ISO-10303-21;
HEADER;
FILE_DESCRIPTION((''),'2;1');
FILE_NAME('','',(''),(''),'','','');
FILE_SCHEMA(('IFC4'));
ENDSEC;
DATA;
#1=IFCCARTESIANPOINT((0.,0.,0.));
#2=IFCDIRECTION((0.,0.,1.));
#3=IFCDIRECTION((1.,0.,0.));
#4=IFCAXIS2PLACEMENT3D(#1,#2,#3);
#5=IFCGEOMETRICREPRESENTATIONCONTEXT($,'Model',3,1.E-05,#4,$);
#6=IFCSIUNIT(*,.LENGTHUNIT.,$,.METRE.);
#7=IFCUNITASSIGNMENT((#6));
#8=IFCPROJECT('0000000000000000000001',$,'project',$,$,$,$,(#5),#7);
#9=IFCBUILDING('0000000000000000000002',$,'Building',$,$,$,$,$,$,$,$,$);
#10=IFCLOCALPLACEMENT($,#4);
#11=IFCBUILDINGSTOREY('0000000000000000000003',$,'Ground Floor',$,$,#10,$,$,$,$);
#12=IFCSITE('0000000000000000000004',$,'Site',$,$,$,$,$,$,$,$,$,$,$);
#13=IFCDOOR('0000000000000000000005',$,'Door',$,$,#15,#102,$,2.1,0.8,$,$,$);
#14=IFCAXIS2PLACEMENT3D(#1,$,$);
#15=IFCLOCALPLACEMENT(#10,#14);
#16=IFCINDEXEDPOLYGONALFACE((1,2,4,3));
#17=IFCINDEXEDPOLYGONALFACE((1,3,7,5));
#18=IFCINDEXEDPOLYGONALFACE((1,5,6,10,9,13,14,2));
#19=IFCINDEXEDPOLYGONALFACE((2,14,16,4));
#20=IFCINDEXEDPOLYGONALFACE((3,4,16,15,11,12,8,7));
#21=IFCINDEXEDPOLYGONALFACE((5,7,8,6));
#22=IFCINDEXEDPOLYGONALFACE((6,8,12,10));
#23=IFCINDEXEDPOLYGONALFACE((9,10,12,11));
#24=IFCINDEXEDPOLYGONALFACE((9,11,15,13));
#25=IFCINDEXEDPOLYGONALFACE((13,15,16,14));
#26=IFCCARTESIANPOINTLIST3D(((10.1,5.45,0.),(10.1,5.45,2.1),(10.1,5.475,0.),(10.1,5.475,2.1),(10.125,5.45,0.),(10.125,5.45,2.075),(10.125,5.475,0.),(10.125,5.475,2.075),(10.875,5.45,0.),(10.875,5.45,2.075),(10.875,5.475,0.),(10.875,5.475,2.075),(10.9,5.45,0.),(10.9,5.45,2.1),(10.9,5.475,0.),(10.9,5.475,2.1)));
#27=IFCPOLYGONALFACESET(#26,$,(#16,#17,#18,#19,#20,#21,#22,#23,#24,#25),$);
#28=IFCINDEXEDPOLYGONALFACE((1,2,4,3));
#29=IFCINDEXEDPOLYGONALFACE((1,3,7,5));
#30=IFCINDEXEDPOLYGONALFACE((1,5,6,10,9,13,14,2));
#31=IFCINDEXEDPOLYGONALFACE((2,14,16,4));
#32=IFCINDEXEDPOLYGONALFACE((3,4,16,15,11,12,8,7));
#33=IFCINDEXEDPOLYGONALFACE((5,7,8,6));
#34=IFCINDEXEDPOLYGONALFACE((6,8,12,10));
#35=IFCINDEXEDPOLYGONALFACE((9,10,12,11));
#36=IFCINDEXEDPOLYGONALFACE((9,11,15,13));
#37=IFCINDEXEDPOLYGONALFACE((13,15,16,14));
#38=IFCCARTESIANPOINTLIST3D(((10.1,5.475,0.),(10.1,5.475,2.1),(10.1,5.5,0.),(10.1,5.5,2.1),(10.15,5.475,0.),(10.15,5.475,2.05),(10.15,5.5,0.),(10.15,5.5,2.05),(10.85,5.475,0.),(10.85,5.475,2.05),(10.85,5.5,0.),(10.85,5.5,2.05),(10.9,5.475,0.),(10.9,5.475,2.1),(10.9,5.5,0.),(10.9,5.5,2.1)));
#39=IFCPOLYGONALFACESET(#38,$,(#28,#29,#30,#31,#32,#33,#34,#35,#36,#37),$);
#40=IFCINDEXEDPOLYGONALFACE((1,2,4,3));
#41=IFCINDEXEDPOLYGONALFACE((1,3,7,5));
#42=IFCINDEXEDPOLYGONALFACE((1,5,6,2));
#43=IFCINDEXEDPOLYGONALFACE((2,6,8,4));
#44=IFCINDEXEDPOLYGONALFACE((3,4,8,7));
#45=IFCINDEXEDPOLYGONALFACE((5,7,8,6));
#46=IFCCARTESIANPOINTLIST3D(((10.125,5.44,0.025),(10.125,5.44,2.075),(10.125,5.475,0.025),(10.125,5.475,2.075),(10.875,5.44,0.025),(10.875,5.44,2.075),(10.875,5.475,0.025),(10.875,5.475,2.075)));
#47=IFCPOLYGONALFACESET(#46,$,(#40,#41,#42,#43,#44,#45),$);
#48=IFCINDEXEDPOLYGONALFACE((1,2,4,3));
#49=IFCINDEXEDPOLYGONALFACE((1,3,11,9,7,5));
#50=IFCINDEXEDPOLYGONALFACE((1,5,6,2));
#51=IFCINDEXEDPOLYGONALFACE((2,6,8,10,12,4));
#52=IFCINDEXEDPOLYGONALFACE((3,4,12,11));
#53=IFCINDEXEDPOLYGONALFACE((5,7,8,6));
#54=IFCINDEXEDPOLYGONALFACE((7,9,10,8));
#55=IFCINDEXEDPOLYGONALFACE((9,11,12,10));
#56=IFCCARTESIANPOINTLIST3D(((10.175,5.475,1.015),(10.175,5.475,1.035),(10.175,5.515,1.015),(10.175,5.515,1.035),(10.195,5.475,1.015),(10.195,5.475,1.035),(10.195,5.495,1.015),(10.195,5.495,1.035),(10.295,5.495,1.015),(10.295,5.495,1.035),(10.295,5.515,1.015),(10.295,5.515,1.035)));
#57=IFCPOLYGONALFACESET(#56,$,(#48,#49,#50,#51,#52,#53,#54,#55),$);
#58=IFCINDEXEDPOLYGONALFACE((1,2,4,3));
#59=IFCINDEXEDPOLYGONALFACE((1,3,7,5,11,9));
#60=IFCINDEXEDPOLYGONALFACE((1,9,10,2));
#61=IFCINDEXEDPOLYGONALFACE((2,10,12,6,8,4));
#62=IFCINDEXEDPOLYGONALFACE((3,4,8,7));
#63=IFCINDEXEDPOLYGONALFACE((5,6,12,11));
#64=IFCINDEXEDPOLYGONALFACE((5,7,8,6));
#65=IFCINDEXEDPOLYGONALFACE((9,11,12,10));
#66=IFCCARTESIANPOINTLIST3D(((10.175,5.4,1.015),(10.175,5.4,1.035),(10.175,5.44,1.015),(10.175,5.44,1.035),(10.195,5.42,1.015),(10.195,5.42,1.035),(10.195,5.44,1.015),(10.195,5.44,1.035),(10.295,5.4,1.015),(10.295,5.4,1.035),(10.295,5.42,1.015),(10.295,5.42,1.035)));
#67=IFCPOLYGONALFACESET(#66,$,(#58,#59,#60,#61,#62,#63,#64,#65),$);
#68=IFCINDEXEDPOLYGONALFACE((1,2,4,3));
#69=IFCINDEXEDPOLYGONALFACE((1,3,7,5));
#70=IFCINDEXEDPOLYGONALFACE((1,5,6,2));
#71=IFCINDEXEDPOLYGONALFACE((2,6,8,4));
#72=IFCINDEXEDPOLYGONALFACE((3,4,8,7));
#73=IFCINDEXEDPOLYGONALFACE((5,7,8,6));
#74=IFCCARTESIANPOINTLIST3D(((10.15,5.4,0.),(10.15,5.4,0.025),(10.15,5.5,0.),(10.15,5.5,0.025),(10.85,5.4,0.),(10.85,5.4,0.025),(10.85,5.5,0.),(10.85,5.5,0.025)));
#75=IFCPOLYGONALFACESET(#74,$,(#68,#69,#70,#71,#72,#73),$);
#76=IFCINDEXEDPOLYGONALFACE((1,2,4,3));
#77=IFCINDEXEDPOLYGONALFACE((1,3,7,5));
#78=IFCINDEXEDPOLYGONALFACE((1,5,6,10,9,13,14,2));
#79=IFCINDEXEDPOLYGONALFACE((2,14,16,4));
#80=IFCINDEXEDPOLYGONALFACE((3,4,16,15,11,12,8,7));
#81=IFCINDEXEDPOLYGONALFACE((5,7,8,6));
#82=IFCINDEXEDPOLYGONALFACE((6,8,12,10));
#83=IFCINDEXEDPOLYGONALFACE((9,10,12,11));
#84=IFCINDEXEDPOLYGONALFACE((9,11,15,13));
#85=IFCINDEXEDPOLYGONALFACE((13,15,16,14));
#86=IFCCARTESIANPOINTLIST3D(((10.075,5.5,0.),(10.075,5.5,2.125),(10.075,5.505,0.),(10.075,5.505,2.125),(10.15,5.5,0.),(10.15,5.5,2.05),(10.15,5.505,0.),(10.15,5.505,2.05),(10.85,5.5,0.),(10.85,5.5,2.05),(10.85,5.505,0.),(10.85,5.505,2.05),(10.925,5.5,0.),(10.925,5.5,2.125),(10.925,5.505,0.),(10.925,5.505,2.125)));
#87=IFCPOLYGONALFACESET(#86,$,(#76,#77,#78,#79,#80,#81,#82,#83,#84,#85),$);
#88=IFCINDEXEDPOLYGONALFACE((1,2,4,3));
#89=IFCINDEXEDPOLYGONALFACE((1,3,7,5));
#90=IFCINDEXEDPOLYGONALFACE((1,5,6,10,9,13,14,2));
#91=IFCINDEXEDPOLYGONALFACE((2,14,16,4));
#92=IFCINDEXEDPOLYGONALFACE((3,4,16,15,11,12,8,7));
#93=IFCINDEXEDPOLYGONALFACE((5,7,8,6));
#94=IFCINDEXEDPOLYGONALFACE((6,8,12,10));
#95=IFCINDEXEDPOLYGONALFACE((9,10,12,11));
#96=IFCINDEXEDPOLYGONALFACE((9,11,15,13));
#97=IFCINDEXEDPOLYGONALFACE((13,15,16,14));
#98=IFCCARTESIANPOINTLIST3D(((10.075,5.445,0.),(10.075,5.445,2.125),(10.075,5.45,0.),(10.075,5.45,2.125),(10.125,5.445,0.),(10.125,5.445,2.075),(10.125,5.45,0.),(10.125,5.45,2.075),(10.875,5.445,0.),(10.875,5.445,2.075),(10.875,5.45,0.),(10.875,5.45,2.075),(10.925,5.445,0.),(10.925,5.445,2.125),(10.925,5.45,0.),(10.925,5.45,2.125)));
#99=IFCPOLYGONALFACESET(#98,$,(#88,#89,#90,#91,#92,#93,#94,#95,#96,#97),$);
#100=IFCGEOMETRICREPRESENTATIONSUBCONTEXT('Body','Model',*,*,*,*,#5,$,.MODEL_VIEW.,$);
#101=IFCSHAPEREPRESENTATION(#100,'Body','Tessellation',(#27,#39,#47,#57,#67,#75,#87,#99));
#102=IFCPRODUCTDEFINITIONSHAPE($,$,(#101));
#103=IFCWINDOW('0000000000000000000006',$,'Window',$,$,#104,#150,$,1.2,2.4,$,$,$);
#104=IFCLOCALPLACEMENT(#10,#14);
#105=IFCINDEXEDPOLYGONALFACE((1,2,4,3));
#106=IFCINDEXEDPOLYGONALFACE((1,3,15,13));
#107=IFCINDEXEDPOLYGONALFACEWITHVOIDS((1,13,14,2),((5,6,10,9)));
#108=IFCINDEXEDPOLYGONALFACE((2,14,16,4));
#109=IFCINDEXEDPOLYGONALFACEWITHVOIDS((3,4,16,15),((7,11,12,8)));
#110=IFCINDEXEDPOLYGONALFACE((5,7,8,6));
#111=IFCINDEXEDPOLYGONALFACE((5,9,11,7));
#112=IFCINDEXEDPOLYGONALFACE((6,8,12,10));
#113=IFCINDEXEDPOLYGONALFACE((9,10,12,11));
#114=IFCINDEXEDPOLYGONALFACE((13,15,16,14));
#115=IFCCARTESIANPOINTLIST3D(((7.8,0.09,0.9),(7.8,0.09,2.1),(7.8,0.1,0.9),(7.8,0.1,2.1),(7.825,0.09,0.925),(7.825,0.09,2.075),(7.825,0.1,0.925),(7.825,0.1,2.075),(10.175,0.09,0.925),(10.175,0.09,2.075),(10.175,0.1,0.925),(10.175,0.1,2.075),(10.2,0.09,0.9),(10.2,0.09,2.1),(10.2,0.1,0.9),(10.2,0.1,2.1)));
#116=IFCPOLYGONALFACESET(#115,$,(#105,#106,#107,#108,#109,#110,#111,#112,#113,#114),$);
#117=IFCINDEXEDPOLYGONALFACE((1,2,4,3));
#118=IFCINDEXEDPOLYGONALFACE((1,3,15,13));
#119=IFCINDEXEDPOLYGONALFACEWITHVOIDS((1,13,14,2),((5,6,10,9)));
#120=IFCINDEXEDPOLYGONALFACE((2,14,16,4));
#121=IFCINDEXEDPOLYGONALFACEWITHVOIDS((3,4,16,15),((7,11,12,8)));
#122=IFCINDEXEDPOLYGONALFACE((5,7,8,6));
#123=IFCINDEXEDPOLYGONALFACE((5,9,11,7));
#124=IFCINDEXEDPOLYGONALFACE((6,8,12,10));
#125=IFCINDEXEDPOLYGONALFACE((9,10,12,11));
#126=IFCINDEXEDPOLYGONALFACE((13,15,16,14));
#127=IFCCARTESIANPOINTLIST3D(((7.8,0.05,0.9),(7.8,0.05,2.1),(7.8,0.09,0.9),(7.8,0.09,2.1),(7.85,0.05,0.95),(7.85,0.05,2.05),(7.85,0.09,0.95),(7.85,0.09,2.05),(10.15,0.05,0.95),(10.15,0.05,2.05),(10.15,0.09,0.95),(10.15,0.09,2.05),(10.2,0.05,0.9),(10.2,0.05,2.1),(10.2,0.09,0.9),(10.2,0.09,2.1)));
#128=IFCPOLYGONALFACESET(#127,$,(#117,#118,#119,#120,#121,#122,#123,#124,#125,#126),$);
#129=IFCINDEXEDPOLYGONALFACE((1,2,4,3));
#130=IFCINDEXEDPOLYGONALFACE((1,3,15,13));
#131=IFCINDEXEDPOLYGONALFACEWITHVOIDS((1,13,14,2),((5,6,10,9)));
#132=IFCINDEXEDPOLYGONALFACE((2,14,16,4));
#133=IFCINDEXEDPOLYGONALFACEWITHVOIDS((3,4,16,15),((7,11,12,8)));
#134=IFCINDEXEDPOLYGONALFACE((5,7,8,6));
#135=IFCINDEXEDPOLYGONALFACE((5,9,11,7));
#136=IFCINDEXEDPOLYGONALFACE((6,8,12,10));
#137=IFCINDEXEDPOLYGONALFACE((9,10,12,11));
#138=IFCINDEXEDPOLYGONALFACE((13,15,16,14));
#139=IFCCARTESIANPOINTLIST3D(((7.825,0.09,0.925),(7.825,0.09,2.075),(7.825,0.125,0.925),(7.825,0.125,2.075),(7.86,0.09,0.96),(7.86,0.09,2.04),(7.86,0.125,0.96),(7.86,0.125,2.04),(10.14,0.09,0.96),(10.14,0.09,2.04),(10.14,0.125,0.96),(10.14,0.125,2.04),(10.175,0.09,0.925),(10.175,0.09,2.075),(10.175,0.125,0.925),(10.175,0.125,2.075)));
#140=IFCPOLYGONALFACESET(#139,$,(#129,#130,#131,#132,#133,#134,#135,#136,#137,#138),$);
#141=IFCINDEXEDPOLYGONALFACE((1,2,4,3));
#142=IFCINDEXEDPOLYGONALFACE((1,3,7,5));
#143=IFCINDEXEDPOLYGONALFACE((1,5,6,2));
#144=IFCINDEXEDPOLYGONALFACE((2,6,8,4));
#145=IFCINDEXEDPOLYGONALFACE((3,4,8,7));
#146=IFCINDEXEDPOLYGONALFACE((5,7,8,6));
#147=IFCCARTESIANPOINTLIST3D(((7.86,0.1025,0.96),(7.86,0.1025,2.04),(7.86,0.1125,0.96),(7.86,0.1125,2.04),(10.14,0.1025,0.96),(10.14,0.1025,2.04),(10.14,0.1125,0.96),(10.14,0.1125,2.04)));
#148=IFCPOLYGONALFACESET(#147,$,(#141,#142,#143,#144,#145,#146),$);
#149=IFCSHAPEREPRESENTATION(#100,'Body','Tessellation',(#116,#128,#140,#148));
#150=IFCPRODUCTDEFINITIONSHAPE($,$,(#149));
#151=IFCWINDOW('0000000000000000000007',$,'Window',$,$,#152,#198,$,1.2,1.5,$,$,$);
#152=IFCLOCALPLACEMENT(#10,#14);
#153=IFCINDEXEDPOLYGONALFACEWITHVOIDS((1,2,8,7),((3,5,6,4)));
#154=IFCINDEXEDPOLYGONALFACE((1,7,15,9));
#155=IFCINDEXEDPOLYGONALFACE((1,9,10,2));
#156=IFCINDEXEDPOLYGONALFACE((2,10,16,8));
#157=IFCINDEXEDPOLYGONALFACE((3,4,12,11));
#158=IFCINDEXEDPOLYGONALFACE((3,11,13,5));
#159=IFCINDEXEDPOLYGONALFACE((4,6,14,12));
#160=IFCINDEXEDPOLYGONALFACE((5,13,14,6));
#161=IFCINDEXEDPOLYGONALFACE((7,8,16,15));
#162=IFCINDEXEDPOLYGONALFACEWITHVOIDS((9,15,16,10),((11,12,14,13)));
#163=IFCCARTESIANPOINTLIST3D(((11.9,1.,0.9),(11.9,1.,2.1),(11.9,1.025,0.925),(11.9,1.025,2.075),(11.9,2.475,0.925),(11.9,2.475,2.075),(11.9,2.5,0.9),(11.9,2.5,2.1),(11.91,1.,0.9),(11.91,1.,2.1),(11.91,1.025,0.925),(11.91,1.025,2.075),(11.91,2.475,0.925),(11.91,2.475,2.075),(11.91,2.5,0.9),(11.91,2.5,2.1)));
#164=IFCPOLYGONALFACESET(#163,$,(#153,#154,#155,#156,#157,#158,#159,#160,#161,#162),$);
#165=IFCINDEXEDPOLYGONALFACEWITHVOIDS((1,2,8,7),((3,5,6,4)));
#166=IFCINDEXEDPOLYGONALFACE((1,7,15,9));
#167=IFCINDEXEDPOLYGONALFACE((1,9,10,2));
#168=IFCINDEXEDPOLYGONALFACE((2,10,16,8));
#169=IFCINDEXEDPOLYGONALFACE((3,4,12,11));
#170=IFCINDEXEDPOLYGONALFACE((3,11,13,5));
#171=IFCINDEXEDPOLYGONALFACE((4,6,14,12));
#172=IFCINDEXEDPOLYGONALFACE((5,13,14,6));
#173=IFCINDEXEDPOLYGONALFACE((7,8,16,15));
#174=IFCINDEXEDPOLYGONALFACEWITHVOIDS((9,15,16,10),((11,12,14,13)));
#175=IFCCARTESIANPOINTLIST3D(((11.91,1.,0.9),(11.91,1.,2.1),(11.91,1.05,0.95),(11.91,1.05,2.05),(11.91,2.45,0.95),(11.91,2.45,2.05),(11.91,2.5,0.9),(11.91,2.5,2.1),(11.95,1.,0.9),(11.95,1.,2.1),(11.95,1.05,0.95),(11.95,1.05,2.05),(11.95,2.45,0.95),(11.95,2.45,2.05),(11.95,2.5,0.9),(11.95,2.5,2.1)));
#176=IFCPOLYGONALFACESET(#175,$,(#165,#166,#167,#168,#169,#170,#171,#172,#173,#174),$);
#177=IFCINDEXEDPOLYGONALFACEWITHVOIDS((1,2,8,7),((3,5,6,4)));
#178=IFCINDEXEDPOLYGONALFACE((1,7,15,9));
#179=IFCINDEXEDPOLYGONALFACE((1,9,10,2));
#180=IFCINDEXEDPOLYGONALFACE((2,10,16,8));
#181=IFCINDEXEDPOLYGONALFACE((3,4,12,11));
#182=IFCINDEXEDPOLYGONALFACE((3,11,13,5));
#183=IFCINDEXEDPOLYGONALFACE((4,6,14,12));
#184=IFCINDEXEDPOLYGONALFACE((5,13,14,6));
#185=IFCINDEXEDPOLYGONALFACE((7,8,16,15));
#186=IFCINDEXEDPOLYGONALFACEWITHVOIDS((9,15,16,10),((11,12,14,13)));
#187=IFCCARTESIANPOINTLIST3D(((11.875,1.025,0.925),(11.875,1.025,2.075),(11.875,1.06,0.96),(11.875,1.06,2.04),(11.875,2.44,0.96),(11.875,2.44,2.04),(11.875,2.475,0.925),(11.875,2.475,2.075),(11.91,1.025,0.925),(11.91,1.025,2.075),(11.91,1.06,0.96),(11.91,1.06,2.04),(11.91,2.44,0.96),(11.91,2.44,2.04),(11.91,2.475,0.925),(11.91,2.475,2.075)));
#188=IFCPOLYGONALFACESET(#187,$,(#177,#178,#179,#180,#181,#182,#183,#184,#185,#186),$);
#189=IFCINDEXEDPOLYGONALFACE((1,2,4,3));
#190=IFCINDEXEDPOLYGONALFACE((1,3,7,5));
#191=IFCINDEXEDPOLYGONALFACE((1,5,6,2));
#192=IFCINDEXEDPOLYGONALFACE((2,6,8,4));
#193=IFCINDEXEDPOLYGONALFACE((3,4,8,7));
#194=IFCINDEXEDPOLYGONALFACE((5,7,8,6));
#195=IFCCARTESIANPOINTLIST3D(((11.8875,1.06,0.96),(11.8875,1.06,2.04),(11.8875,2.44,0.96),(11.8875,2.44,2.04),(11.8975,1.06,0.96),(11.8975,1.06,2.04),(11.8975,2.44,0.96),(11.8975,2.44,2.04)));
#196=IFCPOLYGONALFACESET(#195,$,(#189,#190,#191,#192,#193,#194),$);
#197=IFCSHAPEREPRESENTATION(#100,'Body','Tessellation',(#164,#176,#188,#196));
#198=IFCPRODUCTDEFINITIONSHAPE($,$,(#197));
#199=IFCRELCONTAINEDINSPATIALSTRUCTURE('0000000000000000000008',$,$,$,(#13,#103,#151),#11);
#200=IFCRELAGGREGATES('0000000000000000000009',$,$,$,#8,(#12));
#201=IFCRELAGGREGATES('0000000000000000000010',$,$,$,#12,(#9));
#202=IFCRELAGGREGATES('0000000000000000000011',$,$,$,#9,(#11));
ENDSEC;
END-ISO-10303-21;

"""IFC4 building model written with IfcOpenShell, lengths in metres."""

from ifc_helpers import new_model, si_unit, frame, origin_with_axes, place, context, subcontext, project, spatial, line, indexed_curve, outline, extrude, element, save


model = new_model("IFC4")

# Units and contexts
model_context = context("Model", 3, precision=1e-05, world=origin_with_axes())
body_context = subcontext(model_context, "Body", "Model", "MODEL_VIEW")
ifc_project = project(units=[si_unit("LENGTHUNIT", "METRE")], contexts=[model_context])

# Site, building, storey
site = spatial("IfcSite", under=ifc_project, Name="Site")
building = spatial("IfcBuilding", under=site, Name="Building")
storey_placement = place(None, origin_with_axes())
storey = spatial("IfcBuildingStorey", under=building, at=storey_placement, Name="Ground Floor")

# Door
door_1_placement = place(storey_placement, frame((10.9, 5.5, 0.0), z_axis=(0.0, 0.0, 1.0), x_axis=(-1.0, 0.0, 0.0)))
element("IfcDoor", 1, at=door_1_placement, inside=storey, Name="Door", OverallHeight=2.1, OverallWidth=0.8, context=body_context, shape_type="SweptSolid", body=[
    extrude(outline(indexed_curve([(0.0, 0.0), (0.0, 2.1), (0.8, 2.1), (0.8, 0.0), (0.775, 0.0), (0.775, 2.075), (0.025, 2.075), (0.025, 0.0)], segments=[line(1, 2, 3, 4, 5, 6, 7, 8, 1)])), frame((0.0, 0.025, 0.0), z_axis=(0.0, -1.0, 0.0), x_axis=(1.0, 0.0, 0.0)), (0.0, 0.0, -1.0), 0.025),
    extrude(outline(indexed_curve([(0.0, 0.0), (0.0, 2.1), (0.8, 2.1), (0.8, 0.0), (0.75, 0.0), (0.75, 2.05), (0.05, 2.05), (0.05, 0.0)], segments=[line(1, 2, 3, 4, 5, 6, 7, 8, 1)])), frame((0.0, 0.0, 0.0), z_axis=(0.0, -1.0, 0.0), x_axis=(1.0, 0.0, 0.0)), (0.0, 0.0, -1.0), 0.025),
    extrude(outline(indexed_curve([(0.0, 0.0), (0.75, 0.0), (0.75, 0.035), (0.0, 0.035)], segments=[line(1, 2, 3, 4, 1)])), frame((0.025, 0.025, 0.025), z_axis=(0.0, 0.0, 1.0), x_axis=(1.0, 0.0, 0.0)), (0.0, 0.0, 1.0), 2.05),
    extrude(outline(indexed_curve([(0.0, 0.0), (0.0, -0.04), (-0.12, -0.04), (-0.12, -0.02), (-0.02, -0.02), (-0.02, 0.0)], segments=[line(1, 2, 3, 4, 5, 6, 1)])), frame((0.725, 0.025, 1.015), z_axis=(0.0, 0.0, 1.0), x_axis=(1.0, 0.0, 0.0)), (0.0, 0.0, 1.0), 0.02),
    extrude(outline(indexed_curve([(0.0, 0.0), (0.0, 0.04), (-0.12, 0.04), (-0.12, 0.02), (-0.02, 0.02), (-0.02, 0.0)], segments=[line(1, 2, 3, 4, 5, 6, 1)])), frame((0.725, 0.06, 1.015), z_axis=(0.0, 0.0, 1.0), x_axis=(1.0, 0.0, 0.0)), (0.0, 0.0, 1.0), 0.02),
    extrude(outline(indexed_curve([(0.0, 0.0), (0.7, 0.0), (0.7, 0.1), (0.0, 0.1)], segments=[line(1, 2, 3, 4, 1)])), frame((0.05, 0.0, 0.0), z_axis=(0.0, 0.0, 1.0), x_axis=(1.0, 0.0, 0.0)), (0.0, 0.0, 1.0), 0.025),
    extrude(outline(indexed_curve([(0.0, 0.0), (0.0, 2.125), (0.85, 2.125), (0.85, 0.0), (0.775, 0.0), (0.775, 2.05), (0.075, 2.05), (0.075, 0.0)], segments=[line(1, 2, 3, 4, 5, 6, 7, 8, 1)])), frame((-0.025, -0.005, 0.0), z_axis=(0.0, -1.0, 0.0), x_axis=(1.0, 0.0, 0.0)), (0.0, 0.0, -1.0), 0.005),
    extrude(outline(indexed_curve([(0.0, 0.0), (0.0, 2.125), (0.85, 2.125), (0.85, 0.0), (0.8, 0.0), (0.8, 2.075), (0.05, 2.075), (0.05, 0.0)], segments=[line(1, 2, 3, 4, 5, 6, 7, 8, 1)])), frame((-0.025, 0.05, 0.0), z_axis=(0.0, -1.0, 0.0), x_axis=(1.0, 0.0, 0.0)), (0.0, 0.0, -1.0), 0.005),
])

# Windows
window_1_placement = place(storey_placement, frame((7.8, 0.0, 0.9), z_axis=(0.0, 0.0, 1.0), x_axis=(1.0, 0.0, 0.0)))
element("IfcWindow", 2, at=window_1_placement, inside=storey, Name="Window", OverallHeight=1.2, OverallWidth=2.4, context=body_context, shape_type="SweptSolid", body=[
    extrude(outline(indexed_curve([(0.0, 0.0), (2.4, 0.0), (2.4, 1.2), (0.0, 1.2)], segments=[line(1, 2, 3, 4, 1)]), holes=[indexed_curve([(0.025, 0.025), (2.375, 0.025), (2.375, 1.175), (0.025, 1.175)], segments=[line(1, 2, 3, 4, 1)])]), frame((0.0, 0.09, 0.0), z_axis=(0.0, -1.0, 0.0), x_axis=(1.0, 0.0, 0.0)), (0.0, 0.0, -1.0), 0.01),
    extrude(outline(indexed_curve([(0.0, 0.0), (2.4, 0.0), (2.4, 1.2), (0.0, 1.2)], segments=[line(1, 2, 3, 4, 1)]), holes=[indexed_curve([(0.05, 0.05), (2.35, 0.05), (2.35, 1.15), (0.05, 1.15)], segments=[line(1, 2, 3, 4, 1)])]), frame((0.0, 0.05, 0.0), z_axis=(0.0, -1.0, 0.0), x_axis=(1.0, 0.0, 0.0)), (0.0, 0.0, -1.0), 0.04),
    extrude(outline(indexed_curve([(0.0, 0.0), (2.35, 0.0), (2.35, 1.15), (0.0, 1.15)], segments=[line(1, 2, 3, 4, 1)]), holes=[indexed_curve([(0.035, 0.035), (2.315, 0.035), (2.315, 1.115), (0.035, 1.115)], segments=[line(1, 2, 3, 4, 1)])]), frame((0.025, 0.09, 0.025), z_axis=(0.0, -1.0, 0.0), x_axis=(1.0, 0.0, 0.0)), (0.0, 0.0, -1.0), 0.035),
    extrude(outline(indexed_curve([(0.035, 0.035), (2.315, 0.035), (2.315, 1.115), (0.035, 1.115)], segments=[line(1, 2, 3, 4, 1)])), frame((0.025, 0.1025, 0.025), z_axis=(0.0, -1.0, 0.0), x_axis=(1.0, 0.0, 0.0)), (0.0, 0.0, -1.0), 0.01),
])
for number, where, z_axis, x_axis, name in (
    (3, (12.0, 1.0, 0.9), (0.0, 0.0, 1.0), (0.0, 1.0, 0.0), "Window"),
):
    element("IfcWindow", number, at=place(storey_placement, frame(where, z_axis=z_axis, x_axis=x_axis)), inside=storey, Name=name, OverallHeight=1.2, OverallWidth=1.5, context=body_context, shape_type="SweptSolid", body=[
        extrude(outline(indexed_curve([(0.0, 0.0), (1.5, 0.0), (1.5, 1.2), (0.0, 1.2)], segments=[line(1, 2, 3, 4, 1)]), holes=[indexed_curve([(0.025, 0.025), (1.475, 0.025), (1.475, 1.175), (0.025, 1.175)], segments=[line(1, 2, 3, 4, 1)])]), frame((0.0, 0.09, 0.0), z_axis=(0.0, -1.0, 0.0), x_axis=(1.0, 0.0, 0.0)), (0.0, 0.0, -1.0), 0.01),
        extrude(outline(indexed_curve([(0.0, 0.0), (1.5, 0.0), (1.5, 1.2), (0.0, 1.2)], segments=[line(1, 2, 3, 4, 1)]), holes=[indexed_curve([(0.05, 0.05), (1.45, 0.05), (1.45, 1.15), (0.05, 1.15)], segments=[line(1, 2, 3, 4, 1)])]), frame((0.0, 0.05, 0.0), z_axis=(0.0, -1.0, 0.0), x_axis=(1.0, 0.0, 0.0)), (0.0, 0.0, -1.0), 0.04),
        extrude(outline(indexed_curve([(0.0, 0.0), (1.45, 0.0), (1.45, 1.15), (0.0, 1.15)], segments=[line(1, 2, 3, 4, 1)]), holes=[indexed_curve([(0.035, 0.035), (1.415, 0.035), (1.415, 1.115), (0.035, 1.115)], segments=[line(1, 2, 3, 4, 1)])]), frame((0.025, 0.09, 0.025), z_axis=(0.0, -1.0, 0.0), x_axis=(1.0, 0.0, 0.0)), (0.0, 0.0, -1.0), 0.035),
        extrude(outline(indexed_curve([(0.035, 0.035), (1.415, 0.035), (1.415, 1.115), (0.035, 1.115)], segments=[line(1, 2, 3, 4, 1)])), frame((0.025, 0.1025, 0.025), z_axis=(0.0, -1.0, 0.0), x_axis=(1.0, 0.0, 0.0)), (0.0, 0.0, -1.0), 0.01),
    ])

save(model, "model.ifc")
